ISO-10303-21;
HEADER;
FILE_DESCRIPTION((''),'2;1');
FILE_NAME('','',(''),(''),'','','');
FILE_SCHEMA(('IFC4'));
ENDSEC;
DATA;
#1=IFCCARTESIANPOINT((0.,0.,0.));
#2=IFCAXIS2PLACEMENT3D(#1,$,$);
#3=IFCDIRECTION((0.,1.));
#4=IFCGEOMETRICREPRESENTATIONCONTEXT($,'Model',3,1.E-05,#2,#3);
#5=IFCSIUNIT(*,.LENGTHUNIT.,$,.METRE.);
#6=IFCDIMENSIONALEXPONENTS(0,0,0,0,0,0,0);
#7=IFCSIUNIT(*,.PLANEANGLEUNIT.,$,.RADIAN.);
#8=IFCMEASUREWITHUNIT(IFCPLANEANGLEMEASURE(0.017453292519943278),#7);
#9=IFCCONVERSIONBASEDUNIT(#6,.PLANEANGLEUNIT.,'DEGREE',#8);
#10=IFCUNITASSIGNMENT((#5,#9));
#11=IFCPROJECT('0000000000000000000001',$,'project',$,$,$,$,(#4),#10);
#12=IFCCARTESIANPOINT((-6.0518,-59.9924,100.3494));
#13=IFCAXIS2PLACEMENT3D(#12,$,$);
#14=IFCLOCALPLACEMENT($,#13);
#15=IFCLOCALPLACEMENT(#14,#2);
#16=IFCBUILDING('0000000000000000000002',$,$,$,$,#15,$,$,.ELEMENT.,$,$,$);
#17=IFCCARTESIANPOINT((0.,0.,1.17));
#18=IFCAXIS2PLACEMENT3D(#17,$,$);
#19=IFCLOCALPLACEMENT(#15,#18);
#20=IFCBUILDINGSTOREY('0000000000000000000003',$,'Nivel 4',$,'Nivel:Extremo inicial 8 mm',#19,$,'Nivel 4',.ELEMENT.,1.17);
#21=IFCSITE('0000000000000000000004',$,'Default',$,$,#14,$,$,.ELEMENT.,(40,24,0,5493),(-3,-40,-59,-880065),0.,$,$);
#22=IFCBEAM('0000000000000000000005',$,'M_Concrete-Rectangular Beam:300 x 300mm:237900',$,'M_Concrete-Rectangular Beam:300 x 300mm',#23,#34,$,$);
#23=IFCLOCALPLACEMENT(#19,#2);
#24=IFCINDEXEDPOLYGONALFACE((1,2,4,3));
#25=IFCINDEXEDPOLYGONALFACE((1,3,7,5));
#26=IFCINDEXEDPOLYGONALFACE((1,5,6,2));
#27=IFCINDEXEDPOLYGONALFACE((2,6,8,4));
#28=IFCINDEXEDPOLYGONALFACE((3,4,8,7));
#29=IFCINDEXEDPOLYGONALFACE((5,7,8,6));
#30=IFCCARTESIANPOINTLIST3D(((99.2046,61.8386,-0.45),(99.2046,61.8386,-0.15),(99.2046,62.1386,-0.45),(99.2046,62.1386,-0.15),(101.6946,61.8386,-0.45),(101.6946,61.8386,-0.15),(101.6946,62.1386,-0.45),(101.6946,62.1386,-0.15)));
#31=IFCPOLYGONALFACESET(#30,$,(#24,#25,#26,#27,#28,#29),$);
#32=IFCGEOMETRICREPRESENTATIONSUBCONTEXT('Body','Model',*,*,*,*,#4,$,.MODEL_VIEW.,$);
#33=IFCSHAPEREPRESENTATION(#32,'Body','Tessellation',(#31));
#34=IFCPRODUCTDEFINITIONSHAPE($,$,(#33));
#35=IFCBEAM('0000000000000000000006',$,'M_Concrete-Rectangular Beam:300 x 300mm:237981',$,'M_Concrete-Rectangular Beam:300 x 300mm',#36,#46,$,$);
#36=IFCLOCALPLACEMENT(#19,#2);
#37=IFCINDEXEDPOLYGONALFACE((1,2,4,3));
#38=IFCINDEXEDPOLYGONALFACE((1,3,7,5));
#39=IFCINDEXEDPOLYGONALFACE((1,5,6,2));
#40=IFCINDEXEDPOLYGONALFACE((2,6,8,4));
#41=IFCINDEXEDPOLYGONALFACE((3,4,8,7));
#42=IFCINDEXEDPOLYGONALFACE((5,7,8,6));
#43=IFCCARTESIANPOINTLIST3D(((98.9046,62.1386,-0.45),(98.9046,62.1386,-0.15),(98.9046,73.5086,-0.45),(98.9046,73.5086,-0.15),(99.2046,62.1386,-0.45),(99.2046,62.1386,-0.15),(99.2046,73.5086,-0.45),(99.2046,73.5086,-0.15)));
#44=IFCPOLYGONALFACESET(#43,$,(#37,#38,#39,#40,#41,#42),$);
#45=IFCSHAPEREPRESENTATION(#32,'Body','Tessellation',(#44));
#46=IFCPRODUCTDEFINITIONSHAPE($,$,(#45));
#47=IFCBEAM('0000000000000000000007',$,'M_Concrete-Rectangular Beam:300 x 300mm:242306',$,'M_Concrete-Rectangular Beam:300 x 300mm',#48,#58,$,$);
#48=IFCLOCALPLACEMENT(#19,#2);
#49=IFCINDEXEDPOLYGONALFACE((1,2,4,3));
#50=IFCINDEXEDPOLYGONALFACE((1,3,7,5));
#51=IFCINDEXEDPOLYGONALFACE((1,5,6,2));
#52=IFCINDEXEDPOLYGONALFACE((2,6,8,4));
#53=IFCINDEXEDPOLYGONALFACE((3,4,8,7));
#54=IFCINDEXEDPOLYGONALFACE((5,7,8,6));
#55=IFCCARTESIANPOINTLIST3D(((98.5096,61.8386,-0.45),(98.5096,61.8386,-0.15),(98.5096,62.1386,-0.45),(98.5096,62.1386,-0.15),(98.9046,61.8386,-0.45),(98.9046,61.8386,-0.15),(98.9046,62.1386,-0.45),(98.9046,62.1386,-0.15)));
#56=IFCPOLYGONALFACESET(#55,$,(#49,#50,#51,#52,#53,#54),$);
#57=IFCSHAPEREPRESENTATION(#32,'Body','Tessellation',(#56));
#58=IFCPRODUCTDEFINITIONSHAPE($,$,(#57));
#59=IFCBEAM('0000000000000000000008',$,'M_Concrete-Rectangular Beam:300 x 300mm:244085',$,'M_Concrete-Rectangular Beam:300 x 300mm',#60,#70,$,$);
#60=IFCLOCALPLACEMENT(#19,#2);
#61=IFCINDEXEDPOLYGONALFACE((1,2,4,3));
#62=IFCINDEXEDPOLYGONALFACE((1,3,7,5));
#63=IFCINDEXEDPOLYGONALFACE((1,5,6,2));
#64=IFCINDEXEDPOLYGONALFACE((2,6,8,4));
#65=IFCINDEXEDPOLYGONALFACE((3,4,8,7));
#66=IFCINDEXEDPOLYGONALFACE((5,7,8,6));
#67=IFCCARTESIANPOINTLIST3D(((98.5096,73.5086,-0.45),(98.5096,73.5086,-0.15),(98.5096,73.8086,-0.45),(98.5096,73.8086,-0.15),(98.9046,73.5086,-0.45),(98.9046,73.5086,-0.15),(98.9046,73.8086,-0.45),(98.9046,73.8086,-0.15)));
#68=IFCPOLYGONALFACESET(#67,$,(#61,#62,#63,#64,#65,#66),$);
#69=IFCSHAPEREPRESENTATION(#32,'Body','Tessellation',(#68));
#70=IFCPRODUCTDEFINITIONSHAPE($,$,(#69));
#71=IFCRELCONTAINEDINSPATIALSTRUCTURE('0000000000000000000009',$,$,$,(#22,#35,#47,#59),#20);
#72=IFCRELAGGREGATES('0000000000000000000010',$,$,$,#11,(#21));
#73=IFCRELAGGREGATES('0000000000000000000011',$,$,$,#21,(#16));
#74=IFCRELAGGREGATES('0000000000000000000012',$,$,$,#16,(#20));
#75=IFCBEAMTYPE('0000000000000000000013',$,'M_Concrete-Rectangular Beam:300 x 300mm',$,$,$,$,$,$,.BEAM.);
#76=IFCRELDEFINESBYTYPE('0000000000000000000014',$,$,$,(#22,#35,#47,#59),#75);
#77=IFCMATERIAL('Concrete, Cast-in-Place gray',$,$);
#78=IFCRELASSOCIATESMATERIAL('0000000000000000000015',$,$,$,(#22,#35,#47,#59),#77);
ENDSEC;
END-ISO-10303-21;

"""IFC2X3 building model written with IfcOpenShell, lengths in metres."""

from ifc_helpers import new_model, entity, si_unit, converted_unit, direction, frame, frame_2d, origin, place, context, subcontext, project, spatial, rectangle, extrude, material, type_object, element, save


model = new_model("IFC2X3")

# Units and contexts
model_context = context("Model", 3, precision=1e-05, world=origin(), true_north=direction((0.0, 1.0)))
body_context = subcontext(model_context, "Body", "Model", "MODEL_VIEW")
ifc_project = project(units=[si_unit("LENGTHUNIT", "METRE"), converted_unit("PLANEANGLEUNIT", "DEGREE", entity("IfcPlaneAngleMeasure", 0.017453292519943278), si_unit("PLANEANGLEUNIT", "RADIAN"), dimensions=[0, 0, 0, 0, 0, 0, 0])], contexts=[model_context])

# Site, building, storey
site_placement = place(None, frame((-6.0518, -59.9924, 100.3494)))
site = spatial("IfcSite", under=ifc_project, at=site_placement, Name="Default", CompositionType="ELEMENT", RefLatitude=(40, 24, 0, 5493), RefLongitude=(-3, -40, -59, -880065), RefElevation=0.0)
building_placement = place(site_placement, origin())
building = spatial("IfcBuilding", under=site, at=building_placement, CompositionType="ELEMENT")
storey_placement = place(building_placement, frame((0.0, 0.0, 1.17)))
storey = spatial("IfcBuildingStorey", under=building, at=storey_placement, Name="Nivel 4", ObjectType="Nivel:Extremo inicial 8 mm", LongName="Nivel 4", CompositionType="ELEMENT", Elevation=1.17)

# Beams
ifc_material_1 = material(Name="Concrete, Cast-in-Place gray")
beam_type = type_object("IfcBeamType", Name="M_Concrete-Rectangular Beam:300 x 300mm", PredefinedType="BEAM")
beam_1_placement = place(storey_placement, frame((99.0546, 61.9886, 0.0)))
element("IfcBeam", 1, at=beam_1_placement, inside=storey, type_object=beam_type, material=ifc_material_1, Name="M_Concrete-Rectangular Beam:300 x 300mm:237900", ObjectType="M_Concrete-Rectangular Beam:300 x 300mm", context=body_context, shape_type="SweptSolid", body=[
    extrude(rectangle(XDim=0.3, YDim=0.3, at=frame_2d((0.0, 0.0), x_axis=(1.0, 0.0))), frame((0.15, 0.0, -0.3), z_axis=(1.0, 0.0, 0.0), x_axis=(0.0, 0.0, -1.0)), (0.0, 0.0, 1.0), 2.49),
])
beam_2_placement = place(storey_placement, frame((99.0546, 73.6586, 0.0), z_axis=(0.0, 0.0, 1.0), x_axis=(0.0, -1.0, 0.0)))
element("IfcBeam", 2, at=beam_2_placement, inside=storey, type_object=beam_type, material=ifc_material_1, Name="M_Concrete-Rectangular Beam:300 x 300mm:237981", ObjectType="M_Concrete-Rectangular Beam:300 x 300mm", context=body_context, shape_type="SweptSolid", body=[
    extrude(rectangle(XDim=0.3, YDim=0.3, at=frame_2d((0.0, 0.0), x_axis=(1.0, 0.0))), frame((0.15, 0.0, -0.3), z_axis=(1.0, 0.0, 0.0), x_axis=(0.0, 0.0, -1.0)), (0.0, 0.0, 1.0), 11.37),
])
beam_3_placement = place(storey_placement, frame((99.0546, 61.9886, 0.0), z_axis=(0.0, 0.0, 1.0), x_axis=(-1.0, 0.0, 0.0)))
element("IfcBeam", 3, at=beam_3_placement, inside=storey, type_object=beam_type, material=ifc_material_1, Name="M_Concrete-Rectangular Beam:300 x 300mm:242306", ObjectType="M_Concrete-Rectangular Beam:300 x 300mm", context=body_context, shape_type="SweptSolid", body=[
    extrude(rectangle(XDim=0.3, YDim=0.3, at=frame_2d((0.0, 0.0), x_axis=(1.0, 0.0))), frame((0.15, 0.0, -0.3), z_axis=(1.0, 0.0, 0.0), x_axis=(0.0, 0.0, -1.0)), (0.0, 0.0, 1.0), 0.395),
])
beam_4_placement = place(storey_placement, frame((99.0546, 73.6586, 0.0), z_axis=(0.0, 0.0, 1.0), x_axis=(-1.0, 0.0, 0.0)))
element("IfcBeam", 4, at=beam_4_placement, inside=storey, type_object=beam_type, material=ifc_material_1, Name="M_Concrete-Rectangular Beam:300 x 300mm:244085", ObjectType="M_Concrete-Rectangular Beam:300 x 300mm", context=body_context, shape_type="SweptSolid", body=[
    extrude(rectangle(XDim=0.3, YDim=0.3, at=frame_2d((0.0, 0.0), x_axis=(1.0, 0.0))), frame((0.15, 0.0, -0.3), z_axis=(1.0, 0.0, 0.0), x_axis=(0.0, 0.0, -1.0)), (0.0, 0.0, 1.0), 0.395),
])

save(model, "model.ifc")
